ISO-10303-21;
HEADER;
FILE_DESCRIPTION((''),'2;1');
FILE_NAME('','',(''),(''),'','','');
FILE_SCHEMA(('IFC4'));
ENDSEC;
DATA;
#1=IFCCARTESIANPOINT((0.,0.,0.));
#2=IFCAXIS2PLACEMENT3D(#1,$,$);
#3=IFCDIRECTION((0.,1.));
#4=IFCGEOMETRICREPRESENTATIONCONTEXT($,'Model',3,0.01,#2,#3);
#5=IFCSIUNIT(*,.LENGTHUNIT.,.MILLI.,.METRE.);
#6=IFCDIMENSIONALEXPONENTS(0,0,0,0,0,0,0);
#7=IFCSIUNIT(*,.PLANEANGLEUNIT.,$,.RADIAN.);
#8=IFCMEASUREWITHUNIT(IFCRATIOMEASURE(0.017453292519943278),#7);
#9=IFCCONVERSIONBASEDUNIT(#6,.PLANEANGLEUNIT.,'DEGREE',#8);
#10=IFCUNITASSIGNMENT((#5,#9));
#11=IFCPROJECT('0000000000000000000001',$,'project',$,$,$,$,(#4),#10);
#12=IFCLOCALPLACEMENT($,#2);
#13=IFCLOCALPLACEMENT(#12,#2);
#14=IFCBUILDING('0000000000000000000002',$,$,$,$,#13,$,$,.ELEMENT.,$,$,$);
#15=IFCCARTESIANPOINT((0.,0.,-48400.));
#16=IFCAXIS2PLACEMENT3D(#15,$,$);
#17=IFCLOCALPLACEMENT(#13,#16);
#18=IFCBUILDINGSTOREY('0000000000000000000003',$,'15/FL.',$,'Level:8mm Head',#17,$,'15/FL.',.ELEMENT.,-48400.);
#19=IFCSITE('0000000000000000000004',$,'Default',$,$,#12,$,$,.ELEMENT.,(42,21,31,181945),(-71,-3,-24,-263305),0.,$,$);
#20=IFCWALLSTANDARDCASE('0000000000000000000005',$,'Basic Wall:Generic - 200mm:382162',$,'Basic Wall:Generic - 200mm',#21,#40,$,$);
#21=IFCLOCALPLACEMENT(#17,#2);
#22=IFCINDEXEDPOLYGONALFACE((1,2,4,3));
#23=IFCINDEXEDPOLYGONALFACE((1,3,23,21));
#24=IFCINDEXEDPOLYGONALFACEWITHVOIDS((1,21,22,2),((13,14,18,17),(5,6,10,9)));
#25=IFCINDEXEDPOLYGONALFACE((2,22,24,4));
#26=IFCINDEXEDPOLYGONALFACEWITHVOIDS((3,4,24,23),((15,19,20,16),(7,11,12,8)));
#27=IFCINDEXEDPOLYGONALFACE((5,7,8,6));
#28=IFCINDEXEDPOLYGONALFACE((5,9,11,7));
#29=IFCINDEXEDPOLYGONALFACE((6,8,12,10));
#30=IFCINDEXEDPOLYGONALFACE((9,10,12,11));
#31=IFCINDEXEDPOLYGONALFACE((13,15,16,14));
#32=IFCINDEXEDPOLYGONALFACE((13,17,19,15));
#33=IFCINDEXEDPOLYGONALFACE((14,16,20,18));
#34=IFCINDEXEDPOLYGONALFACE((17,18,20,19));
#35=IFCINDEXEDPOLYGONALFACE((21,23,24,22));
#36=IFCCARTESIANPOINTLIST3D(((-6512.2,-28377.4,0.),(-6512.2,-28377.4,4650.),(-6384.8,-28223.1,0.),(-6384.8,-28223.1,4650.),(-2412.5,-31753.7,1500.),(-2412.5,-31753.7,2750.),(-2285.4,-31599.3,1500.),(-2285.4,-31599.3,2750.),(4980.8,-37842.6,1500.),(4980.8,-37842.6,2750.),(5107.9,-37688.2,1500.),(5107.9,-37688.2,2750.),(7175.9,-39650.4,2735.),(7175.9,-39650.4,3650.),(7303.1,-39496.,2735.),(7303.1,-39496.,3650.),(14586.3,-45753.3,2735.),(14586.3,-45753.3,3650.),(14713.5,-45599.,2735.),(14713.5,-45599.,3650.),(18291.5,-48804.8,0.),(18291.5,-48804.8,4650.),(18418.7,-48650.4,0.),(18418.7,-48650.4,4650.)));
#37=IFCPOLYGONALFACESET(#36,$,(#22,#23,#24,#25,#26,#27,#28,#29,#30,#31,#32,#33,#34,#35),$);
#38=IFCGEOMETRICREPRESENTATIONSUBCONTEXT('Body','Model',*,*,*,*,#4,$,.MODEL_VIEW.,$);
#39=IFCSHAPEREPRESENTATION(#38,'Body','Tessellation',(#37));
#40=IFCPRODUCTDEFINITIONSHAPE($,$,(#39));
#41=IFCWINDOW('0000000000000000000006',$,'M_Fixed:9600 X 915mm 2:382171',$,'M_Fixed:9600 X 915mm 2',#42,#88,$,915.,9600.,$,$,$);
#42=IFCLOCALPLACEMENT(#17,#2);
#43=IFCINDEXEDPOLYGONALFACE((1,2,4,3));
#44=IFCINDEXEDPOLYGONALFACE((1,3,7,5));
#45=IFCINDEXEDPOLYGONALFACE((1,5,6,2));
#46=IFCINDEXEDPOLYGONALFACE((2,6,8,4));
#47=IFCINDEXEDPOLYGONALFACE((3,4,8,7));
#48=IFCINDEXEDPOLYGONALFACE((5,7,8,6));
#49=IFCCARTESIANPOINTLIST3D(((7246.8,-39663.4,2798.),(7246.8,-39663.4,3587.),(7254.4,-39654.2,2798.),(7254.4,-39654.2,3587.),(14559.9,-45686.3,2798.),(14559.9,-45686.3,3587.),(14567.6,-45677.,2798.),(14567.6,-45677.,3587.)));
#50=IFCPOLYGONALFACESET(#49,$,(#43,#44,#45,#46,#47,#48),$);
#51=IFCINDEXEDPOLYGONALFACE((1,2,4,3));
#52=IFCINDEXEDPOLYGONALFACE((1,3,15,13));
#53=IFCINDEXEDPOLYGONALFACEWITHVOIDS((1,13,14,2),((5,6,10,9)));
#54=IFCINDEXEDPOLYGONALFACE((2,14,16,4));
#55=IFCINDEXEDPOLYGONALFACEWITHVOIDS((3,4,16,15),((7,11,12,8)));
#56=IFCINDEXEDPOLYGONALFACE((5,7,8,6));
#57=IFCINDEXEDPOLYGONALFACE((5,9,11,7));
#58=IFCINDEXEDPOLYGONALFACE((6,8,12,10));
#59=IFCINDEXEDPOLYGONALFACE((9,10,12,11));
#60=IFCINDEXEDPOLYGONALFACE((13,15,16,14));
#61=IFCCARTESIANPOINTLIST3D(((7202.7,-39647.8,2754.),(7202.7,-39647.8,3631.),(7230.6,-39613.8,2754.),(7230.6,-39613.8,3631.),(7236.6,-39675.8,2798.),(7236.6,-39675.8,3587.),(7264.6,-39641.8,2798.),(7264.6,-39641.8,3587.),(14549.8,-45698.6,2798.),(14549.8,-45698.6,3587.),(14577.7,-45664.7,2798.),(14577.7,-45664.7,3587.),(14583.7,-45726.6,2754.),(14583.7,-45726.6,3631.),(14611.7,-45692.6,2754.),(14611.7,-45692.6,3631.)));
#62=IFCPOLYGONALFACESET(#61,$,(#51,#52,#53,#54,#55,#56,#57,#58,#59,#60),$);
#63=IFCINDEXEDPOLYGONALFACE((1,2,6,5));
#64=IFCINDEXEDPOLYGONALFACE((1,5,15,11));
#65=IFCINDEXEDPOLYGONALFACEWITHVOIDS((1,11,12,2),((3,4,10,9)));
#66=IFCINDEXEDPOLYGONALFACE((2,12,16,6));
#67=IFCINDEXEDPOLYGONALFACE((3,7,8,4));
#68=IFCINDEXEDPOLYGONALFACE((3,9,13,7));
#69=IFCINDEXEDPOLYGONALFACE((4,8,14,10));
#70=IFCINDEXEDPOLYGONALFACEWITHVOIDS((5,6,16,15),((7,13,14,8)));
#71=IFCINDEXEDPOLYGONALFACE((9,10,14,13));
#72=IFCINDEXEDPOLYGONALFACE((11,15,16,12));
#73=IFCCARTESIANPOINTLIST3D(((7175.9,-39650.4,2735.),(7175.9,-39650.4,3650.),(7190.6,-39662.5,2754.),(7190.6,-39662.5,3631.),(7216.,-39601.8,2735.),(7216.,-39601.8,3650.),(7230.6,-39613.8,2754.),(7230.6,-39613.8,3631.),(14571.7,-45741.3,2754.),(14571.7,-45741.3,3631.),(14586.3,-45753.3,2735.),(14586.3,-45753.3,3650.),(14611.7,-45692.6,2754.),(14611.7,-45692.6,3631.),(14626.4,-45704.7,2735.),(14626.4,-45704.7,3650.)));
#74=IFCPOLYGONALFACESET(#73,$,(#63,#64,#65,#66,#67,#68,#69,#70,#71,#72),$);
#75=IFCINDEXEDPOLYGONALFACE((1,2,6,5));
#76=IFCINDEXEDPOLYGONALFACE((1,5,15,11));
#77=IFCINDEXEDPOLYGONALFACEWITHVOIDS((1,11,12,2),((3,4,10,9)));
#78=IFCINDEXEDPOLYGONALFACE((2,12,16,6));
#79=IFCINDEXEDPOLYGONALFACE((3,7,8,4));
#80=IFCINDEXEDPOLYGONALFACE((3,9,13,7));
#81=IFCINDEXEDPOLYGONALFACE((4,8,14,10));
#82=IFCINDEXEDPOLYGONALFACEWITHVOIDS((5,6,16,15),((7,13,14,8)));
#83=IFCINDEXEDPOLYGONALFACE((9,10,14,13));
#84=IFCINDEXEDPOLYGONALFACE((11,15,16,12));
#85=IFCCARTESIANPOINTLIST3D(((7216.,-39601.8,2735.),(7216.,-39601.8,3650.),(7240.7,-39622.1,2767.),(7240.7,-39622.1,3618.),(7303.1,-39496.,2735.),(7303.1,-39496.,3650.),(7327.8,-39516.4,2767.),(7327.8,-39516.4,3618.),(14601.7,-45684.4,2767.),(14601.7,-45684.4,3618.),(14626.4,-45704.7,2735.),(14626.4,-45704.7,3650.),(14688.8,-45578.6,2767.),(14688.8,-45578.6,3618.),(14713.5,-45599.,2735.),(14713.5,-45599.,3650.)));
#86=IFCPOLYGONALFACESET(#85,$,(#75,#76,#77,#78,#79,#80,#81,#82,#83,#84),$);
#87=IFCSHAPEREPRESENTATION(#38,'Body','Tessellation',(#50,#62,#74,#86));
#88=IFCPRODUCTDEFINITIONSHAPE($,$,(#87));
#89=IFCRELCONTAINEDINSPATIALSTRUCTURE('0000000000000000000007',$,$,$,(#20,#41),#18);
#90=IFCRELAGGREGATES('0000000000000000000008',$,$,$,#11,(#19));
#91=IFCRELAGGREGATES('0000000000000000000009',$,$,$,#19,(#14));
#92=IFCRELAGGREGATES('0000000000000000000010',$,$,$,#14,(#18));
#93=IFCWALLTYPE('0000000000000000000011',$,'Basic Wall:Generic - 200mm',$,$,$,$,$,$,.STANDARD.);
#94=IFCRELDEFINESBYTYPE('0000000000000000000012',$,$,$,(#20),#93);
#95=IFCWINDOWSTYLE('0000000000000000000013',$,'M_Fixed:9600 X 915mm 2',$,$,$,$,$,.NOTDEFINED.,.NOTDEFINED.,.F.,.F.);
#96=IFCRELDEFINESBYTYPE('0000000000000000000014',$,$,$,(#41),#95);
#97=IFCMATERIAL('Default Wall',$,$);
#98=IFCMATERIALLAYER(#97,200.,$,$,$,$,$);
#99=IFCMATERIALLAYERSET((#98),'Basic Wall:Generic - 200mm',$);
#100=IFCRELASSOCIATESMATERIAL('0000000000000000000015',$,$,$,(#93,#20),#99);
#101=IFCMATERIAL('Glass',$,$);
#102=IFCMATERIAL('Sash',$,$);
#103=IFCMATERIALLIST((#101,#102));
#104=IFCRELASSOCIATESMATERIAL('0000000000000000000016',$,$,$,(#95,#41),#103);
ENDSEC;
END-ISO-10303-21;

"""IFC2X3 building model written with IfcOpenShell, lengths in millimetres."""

from ifc_helpers import new_model, entity, si_unit, converted_unit, direction, frame, frame_2d, origin, place, context, subcontext, project, spatial, polyline, rectangle, outline, extrude, source, transform, mapped, material, material_list, layer, layer_set, layer_usage, type_object, type_shapes, element, fill, save


model = new_model("IFC2X3")

# Units and contexts
model_context = context("Model", 3, precision=0.01, world=origin(), true_north=direction((0.0, 1.0)))
body_context = subcontext(model_context, "Body", "Model", "MODEL_VIEW")
ifc_project = project(units=[si_unit("LENGTHUNIT", "METRE", prefix="MILLI"), converted_unit("PLANEANGLEUNIT", "DEGREE", entity("IfcRatioMeasure", 0.017453292519943278), si_unit("PLANEANGLEUNIT", "RADIAN"), dimensions=[0, 0, 0, 0, 0, 0, 0])], contexts=[model_context])

# Site, building, storey
site_placement = place(None, origin())
site = spatial("IfcSite", under=ifc_project, at=site_placement, Name="Default", CompositionType="ELEMENT", RefLatitude=(42, 21, 31, 181945), RefLongitude=(-71, -3, -24, -263305), RefElevation=0.0)
building_placement = place(site_placement, origin())
building = spatial("IfcBuilding", under=site, at=building_placement, CompositionType="ELEMENT")
storey_placement = place(building_placement, frame((0.0, 0.0, -48400.0)))
storey = spatial("IfcBuildingStorey", under=building, at=storey_placement, Name="15/FL.", ObjectType="Level:8mm Head", LongName="15/FL.", CompositionType="ELEMENT", Elevation=-48400.0)

# Shared definitions
ifc_material_1 = material(Name="Default Wall")
ifc_layer = layer(ifc_material_1, 200.0)
ifc_layer_set = layer_set([ifc_layer], Name="Basic Wall:Generic - 200mm")
ifc_layer_usage = layer_usage(ifc_layer_set, "AXIS2", "NEGATIVE", 100.0)
wall_type = type_object("IfcWallType", Name="Basic Wall:Generic - 200mm", PredefinedType="STANDARD", material=ifc_layer_set)

# Shared definitions
ifc_material_2 = material(Name="Glass")
ifc_material_3 = material(Name="Sash")
ifc_material_list = material_list([ifc_material_2, ifc_material_3])

# Wall, openings, window
wall_1_placement = place(storey_placement, frame((-6448.6, -28300.2, 0.0), z_axis=(0.0, 0.0, 1.0), x_axis=(0.771917, -0.635723, 0.0)))
wall_1 = element("IfcWallStandardCase", 1, at=wall_1_placement, inside=storey, type_object=wall_type, material=ifc_layer_usage, Name="Basic Wall:Generic - 200mm:382162", ObjectType="Basic Wall:Generic - 200mm", context=body_context, shape_type="SweptSolid", body=[
    extrude(outline(polyline([(32132.6, -100.0), (32132.6, 100.0), (0.3, 100.0), (0.0, -100.0), (32132.6, -100.0)])), origin(), (0.0, 0.0, 1.0), 4650.0),
])
opening_1_placement = place(wall_1_placement, origin())
element("IfcOpeningElement", 2, at=opening_1_placement, cuts=wall_1, ObjectType="Opening", context=body_context, shape_type="SweptSolid", body=[
    extrude(rectangle(XDim=1250.0, YDim=9577.8, at=frame_2d((0.0, 0.0), x_axis=(1.0, 0.0))), frame((10099.9, -100.0, 2125.0), z_axis=(0.0, 1.0, 0.0), x_axis=(0.0, 0.0, -1.0)), (0.0, 0.0, 1.0), 200.0),
])
opening_2_placement = place(wall_1_placement, frame((-13013.3, 25944.9, 0.0), z_axis=(0.0, 0.0, 1.0), x_axis=(0.771917, 0.635723, 0.0)))
element("IfcOpeningElement", 3, at=opening_2_placement, cuts=wall_1, ObjectType="Opening", context=body_context, shape_type="SweptSolid", body=[
    extrude(rectangle(XDim=1000.0, YDim=1010.1, at=frame_2d((0.0, 0.0), x_axis=(1.0, 0.0))), frame((18673.3, -49135.7, 500.0), z_axis=(0.635723, 0.771917, 0.0), x_axis=(0.0, 0.0, -1.0)), (0.0, 0.0, 1.0), 1012.7),
])
opening_3_placement = place(wall_1_placement, frame((27332.6, 100.0, 2735.0)))
opening_3 = element("IfcOpeningElement", 4, at=opening_3_placement, cuts=wall_1, ObjectType="Opening", context=body_context, shape_type="SweptSolid", body=[
    extrude(rectangle(XDim=915.0, YDim=9600.0, at=frame_2d((457.5, 4800.0), x_axis=(1.0, 0.0))), frame((0.0, 0.0, 0.0), z_axis=(0.0, -1.0, 0.0), x_axis=(0.0, 0.0, 1.0)), (0.0, 0.0, 1.0), 200.0),
])
window_style_1 = type_object("IfcWindowStyle", Name="M_Fixed:9600 X 915mm 2", ConstructionType="NOTDEFINED", OperationType="NOTDEFINED", ParameterTakesPrecedence=False, Sizeable=False, material=ifc_material_list)
shared_shape_1 = source(origin(), body_context, "Body", "SweptSolid", [
    extrude(rectangle(XDim=12.0, YDim=9474.0, at=frame_2d((0.0, 0.0), x_axis=(1.0, 0.0))), frame((4800.0, 159.0, 63.0), z_axis=(0.0, 0.0, 1.0), x_axis=(0.0, -1.0, 0.0)), (0.0, 0.0, 1.0), 789.0),
    extrude(outline(polyline([(-4781.0, -438.5), (4781.0, -438.5), (4781.0, 438.5), (-4781.0, 438.5), (-4781.0, -438.5)]), holes=[polyline([(-4737.0, -394.5), (-4737.0, 394.5), (4737.0, 394.5), (4737.0, -394.5), (-4737.0, -394.5)])]), frame((4800.0, 137.0, 457.5), z_axis=(0.0, 1.0, 0.0), x_axis=(1.0, 0.0, 0.0)), (0.0, 0.0, 1.0), 44.0),
    extrude(outline(polyline([(-4800.0, -457.5), (4800.0, -457.5), (4800.0, 457.5), (-4800.0, 457.5), (-4800.0, -457.5)]), holes=[polyline([(-4781.0, -438.5), (-4781.0, 438.5), (4781.0, 438.5), (4781.0, -438.5), (-4781.0, -438.5)])]), frame((4800.0, 137.0, 457.5), z_axis=(0.0, 1.0, 0.0), x_axis=(1.0, 0.0, 0.0)), (0.0, 0.0, 1.0), 63.0),
    extrude(outline(polyline([(-4800.0, -457.5), (4800.0, -457.5), (4800.0, 457.5), (-4800.0, 457.5), (-4800.0, -457.5)]), holes=[polyline([(-4768.0, -425.5), (-4768.0, 425.5), (4768.0, 425.5), (4768.0, -425.5), (-4768.0, -425.5)])]), frame((4800.0, 0.0, 457.5), z_axis=(0.0, 1.0, 0.0), x_axis=(1.0, 0.0, 0.0)), (0.0, 0.0, 1.0), 137.0),
])
type_shapes(window_style_1, [shared_shape_1])
window_1_placement = place(opening_3_placement, frame((0.0, 0.0, 0.0), z_axis=(0.0, 0.0, 1.0), x_axis=(-1.0, 0.0, 0.0)))
window_1 = element("IfcWindow", 5, at=window_1_placement, inside=storey, type_object=window_style_1, material=ifc_material_list, Name="M_Fixed:9600 X 915mm 2:382171", ObjectType="M_Fixed:9600 X 915mm 2", OverallHeight=915.0, OverallWidth=9600.0, context=body_context, shape_type="MappedRepresentation", body=[
    mapped(shared_shape_1, transform((0.0, 0.0, 0.0), scale=1.0)),
])
fill(opening_3, window_1)

save(model, "model.ifc")
